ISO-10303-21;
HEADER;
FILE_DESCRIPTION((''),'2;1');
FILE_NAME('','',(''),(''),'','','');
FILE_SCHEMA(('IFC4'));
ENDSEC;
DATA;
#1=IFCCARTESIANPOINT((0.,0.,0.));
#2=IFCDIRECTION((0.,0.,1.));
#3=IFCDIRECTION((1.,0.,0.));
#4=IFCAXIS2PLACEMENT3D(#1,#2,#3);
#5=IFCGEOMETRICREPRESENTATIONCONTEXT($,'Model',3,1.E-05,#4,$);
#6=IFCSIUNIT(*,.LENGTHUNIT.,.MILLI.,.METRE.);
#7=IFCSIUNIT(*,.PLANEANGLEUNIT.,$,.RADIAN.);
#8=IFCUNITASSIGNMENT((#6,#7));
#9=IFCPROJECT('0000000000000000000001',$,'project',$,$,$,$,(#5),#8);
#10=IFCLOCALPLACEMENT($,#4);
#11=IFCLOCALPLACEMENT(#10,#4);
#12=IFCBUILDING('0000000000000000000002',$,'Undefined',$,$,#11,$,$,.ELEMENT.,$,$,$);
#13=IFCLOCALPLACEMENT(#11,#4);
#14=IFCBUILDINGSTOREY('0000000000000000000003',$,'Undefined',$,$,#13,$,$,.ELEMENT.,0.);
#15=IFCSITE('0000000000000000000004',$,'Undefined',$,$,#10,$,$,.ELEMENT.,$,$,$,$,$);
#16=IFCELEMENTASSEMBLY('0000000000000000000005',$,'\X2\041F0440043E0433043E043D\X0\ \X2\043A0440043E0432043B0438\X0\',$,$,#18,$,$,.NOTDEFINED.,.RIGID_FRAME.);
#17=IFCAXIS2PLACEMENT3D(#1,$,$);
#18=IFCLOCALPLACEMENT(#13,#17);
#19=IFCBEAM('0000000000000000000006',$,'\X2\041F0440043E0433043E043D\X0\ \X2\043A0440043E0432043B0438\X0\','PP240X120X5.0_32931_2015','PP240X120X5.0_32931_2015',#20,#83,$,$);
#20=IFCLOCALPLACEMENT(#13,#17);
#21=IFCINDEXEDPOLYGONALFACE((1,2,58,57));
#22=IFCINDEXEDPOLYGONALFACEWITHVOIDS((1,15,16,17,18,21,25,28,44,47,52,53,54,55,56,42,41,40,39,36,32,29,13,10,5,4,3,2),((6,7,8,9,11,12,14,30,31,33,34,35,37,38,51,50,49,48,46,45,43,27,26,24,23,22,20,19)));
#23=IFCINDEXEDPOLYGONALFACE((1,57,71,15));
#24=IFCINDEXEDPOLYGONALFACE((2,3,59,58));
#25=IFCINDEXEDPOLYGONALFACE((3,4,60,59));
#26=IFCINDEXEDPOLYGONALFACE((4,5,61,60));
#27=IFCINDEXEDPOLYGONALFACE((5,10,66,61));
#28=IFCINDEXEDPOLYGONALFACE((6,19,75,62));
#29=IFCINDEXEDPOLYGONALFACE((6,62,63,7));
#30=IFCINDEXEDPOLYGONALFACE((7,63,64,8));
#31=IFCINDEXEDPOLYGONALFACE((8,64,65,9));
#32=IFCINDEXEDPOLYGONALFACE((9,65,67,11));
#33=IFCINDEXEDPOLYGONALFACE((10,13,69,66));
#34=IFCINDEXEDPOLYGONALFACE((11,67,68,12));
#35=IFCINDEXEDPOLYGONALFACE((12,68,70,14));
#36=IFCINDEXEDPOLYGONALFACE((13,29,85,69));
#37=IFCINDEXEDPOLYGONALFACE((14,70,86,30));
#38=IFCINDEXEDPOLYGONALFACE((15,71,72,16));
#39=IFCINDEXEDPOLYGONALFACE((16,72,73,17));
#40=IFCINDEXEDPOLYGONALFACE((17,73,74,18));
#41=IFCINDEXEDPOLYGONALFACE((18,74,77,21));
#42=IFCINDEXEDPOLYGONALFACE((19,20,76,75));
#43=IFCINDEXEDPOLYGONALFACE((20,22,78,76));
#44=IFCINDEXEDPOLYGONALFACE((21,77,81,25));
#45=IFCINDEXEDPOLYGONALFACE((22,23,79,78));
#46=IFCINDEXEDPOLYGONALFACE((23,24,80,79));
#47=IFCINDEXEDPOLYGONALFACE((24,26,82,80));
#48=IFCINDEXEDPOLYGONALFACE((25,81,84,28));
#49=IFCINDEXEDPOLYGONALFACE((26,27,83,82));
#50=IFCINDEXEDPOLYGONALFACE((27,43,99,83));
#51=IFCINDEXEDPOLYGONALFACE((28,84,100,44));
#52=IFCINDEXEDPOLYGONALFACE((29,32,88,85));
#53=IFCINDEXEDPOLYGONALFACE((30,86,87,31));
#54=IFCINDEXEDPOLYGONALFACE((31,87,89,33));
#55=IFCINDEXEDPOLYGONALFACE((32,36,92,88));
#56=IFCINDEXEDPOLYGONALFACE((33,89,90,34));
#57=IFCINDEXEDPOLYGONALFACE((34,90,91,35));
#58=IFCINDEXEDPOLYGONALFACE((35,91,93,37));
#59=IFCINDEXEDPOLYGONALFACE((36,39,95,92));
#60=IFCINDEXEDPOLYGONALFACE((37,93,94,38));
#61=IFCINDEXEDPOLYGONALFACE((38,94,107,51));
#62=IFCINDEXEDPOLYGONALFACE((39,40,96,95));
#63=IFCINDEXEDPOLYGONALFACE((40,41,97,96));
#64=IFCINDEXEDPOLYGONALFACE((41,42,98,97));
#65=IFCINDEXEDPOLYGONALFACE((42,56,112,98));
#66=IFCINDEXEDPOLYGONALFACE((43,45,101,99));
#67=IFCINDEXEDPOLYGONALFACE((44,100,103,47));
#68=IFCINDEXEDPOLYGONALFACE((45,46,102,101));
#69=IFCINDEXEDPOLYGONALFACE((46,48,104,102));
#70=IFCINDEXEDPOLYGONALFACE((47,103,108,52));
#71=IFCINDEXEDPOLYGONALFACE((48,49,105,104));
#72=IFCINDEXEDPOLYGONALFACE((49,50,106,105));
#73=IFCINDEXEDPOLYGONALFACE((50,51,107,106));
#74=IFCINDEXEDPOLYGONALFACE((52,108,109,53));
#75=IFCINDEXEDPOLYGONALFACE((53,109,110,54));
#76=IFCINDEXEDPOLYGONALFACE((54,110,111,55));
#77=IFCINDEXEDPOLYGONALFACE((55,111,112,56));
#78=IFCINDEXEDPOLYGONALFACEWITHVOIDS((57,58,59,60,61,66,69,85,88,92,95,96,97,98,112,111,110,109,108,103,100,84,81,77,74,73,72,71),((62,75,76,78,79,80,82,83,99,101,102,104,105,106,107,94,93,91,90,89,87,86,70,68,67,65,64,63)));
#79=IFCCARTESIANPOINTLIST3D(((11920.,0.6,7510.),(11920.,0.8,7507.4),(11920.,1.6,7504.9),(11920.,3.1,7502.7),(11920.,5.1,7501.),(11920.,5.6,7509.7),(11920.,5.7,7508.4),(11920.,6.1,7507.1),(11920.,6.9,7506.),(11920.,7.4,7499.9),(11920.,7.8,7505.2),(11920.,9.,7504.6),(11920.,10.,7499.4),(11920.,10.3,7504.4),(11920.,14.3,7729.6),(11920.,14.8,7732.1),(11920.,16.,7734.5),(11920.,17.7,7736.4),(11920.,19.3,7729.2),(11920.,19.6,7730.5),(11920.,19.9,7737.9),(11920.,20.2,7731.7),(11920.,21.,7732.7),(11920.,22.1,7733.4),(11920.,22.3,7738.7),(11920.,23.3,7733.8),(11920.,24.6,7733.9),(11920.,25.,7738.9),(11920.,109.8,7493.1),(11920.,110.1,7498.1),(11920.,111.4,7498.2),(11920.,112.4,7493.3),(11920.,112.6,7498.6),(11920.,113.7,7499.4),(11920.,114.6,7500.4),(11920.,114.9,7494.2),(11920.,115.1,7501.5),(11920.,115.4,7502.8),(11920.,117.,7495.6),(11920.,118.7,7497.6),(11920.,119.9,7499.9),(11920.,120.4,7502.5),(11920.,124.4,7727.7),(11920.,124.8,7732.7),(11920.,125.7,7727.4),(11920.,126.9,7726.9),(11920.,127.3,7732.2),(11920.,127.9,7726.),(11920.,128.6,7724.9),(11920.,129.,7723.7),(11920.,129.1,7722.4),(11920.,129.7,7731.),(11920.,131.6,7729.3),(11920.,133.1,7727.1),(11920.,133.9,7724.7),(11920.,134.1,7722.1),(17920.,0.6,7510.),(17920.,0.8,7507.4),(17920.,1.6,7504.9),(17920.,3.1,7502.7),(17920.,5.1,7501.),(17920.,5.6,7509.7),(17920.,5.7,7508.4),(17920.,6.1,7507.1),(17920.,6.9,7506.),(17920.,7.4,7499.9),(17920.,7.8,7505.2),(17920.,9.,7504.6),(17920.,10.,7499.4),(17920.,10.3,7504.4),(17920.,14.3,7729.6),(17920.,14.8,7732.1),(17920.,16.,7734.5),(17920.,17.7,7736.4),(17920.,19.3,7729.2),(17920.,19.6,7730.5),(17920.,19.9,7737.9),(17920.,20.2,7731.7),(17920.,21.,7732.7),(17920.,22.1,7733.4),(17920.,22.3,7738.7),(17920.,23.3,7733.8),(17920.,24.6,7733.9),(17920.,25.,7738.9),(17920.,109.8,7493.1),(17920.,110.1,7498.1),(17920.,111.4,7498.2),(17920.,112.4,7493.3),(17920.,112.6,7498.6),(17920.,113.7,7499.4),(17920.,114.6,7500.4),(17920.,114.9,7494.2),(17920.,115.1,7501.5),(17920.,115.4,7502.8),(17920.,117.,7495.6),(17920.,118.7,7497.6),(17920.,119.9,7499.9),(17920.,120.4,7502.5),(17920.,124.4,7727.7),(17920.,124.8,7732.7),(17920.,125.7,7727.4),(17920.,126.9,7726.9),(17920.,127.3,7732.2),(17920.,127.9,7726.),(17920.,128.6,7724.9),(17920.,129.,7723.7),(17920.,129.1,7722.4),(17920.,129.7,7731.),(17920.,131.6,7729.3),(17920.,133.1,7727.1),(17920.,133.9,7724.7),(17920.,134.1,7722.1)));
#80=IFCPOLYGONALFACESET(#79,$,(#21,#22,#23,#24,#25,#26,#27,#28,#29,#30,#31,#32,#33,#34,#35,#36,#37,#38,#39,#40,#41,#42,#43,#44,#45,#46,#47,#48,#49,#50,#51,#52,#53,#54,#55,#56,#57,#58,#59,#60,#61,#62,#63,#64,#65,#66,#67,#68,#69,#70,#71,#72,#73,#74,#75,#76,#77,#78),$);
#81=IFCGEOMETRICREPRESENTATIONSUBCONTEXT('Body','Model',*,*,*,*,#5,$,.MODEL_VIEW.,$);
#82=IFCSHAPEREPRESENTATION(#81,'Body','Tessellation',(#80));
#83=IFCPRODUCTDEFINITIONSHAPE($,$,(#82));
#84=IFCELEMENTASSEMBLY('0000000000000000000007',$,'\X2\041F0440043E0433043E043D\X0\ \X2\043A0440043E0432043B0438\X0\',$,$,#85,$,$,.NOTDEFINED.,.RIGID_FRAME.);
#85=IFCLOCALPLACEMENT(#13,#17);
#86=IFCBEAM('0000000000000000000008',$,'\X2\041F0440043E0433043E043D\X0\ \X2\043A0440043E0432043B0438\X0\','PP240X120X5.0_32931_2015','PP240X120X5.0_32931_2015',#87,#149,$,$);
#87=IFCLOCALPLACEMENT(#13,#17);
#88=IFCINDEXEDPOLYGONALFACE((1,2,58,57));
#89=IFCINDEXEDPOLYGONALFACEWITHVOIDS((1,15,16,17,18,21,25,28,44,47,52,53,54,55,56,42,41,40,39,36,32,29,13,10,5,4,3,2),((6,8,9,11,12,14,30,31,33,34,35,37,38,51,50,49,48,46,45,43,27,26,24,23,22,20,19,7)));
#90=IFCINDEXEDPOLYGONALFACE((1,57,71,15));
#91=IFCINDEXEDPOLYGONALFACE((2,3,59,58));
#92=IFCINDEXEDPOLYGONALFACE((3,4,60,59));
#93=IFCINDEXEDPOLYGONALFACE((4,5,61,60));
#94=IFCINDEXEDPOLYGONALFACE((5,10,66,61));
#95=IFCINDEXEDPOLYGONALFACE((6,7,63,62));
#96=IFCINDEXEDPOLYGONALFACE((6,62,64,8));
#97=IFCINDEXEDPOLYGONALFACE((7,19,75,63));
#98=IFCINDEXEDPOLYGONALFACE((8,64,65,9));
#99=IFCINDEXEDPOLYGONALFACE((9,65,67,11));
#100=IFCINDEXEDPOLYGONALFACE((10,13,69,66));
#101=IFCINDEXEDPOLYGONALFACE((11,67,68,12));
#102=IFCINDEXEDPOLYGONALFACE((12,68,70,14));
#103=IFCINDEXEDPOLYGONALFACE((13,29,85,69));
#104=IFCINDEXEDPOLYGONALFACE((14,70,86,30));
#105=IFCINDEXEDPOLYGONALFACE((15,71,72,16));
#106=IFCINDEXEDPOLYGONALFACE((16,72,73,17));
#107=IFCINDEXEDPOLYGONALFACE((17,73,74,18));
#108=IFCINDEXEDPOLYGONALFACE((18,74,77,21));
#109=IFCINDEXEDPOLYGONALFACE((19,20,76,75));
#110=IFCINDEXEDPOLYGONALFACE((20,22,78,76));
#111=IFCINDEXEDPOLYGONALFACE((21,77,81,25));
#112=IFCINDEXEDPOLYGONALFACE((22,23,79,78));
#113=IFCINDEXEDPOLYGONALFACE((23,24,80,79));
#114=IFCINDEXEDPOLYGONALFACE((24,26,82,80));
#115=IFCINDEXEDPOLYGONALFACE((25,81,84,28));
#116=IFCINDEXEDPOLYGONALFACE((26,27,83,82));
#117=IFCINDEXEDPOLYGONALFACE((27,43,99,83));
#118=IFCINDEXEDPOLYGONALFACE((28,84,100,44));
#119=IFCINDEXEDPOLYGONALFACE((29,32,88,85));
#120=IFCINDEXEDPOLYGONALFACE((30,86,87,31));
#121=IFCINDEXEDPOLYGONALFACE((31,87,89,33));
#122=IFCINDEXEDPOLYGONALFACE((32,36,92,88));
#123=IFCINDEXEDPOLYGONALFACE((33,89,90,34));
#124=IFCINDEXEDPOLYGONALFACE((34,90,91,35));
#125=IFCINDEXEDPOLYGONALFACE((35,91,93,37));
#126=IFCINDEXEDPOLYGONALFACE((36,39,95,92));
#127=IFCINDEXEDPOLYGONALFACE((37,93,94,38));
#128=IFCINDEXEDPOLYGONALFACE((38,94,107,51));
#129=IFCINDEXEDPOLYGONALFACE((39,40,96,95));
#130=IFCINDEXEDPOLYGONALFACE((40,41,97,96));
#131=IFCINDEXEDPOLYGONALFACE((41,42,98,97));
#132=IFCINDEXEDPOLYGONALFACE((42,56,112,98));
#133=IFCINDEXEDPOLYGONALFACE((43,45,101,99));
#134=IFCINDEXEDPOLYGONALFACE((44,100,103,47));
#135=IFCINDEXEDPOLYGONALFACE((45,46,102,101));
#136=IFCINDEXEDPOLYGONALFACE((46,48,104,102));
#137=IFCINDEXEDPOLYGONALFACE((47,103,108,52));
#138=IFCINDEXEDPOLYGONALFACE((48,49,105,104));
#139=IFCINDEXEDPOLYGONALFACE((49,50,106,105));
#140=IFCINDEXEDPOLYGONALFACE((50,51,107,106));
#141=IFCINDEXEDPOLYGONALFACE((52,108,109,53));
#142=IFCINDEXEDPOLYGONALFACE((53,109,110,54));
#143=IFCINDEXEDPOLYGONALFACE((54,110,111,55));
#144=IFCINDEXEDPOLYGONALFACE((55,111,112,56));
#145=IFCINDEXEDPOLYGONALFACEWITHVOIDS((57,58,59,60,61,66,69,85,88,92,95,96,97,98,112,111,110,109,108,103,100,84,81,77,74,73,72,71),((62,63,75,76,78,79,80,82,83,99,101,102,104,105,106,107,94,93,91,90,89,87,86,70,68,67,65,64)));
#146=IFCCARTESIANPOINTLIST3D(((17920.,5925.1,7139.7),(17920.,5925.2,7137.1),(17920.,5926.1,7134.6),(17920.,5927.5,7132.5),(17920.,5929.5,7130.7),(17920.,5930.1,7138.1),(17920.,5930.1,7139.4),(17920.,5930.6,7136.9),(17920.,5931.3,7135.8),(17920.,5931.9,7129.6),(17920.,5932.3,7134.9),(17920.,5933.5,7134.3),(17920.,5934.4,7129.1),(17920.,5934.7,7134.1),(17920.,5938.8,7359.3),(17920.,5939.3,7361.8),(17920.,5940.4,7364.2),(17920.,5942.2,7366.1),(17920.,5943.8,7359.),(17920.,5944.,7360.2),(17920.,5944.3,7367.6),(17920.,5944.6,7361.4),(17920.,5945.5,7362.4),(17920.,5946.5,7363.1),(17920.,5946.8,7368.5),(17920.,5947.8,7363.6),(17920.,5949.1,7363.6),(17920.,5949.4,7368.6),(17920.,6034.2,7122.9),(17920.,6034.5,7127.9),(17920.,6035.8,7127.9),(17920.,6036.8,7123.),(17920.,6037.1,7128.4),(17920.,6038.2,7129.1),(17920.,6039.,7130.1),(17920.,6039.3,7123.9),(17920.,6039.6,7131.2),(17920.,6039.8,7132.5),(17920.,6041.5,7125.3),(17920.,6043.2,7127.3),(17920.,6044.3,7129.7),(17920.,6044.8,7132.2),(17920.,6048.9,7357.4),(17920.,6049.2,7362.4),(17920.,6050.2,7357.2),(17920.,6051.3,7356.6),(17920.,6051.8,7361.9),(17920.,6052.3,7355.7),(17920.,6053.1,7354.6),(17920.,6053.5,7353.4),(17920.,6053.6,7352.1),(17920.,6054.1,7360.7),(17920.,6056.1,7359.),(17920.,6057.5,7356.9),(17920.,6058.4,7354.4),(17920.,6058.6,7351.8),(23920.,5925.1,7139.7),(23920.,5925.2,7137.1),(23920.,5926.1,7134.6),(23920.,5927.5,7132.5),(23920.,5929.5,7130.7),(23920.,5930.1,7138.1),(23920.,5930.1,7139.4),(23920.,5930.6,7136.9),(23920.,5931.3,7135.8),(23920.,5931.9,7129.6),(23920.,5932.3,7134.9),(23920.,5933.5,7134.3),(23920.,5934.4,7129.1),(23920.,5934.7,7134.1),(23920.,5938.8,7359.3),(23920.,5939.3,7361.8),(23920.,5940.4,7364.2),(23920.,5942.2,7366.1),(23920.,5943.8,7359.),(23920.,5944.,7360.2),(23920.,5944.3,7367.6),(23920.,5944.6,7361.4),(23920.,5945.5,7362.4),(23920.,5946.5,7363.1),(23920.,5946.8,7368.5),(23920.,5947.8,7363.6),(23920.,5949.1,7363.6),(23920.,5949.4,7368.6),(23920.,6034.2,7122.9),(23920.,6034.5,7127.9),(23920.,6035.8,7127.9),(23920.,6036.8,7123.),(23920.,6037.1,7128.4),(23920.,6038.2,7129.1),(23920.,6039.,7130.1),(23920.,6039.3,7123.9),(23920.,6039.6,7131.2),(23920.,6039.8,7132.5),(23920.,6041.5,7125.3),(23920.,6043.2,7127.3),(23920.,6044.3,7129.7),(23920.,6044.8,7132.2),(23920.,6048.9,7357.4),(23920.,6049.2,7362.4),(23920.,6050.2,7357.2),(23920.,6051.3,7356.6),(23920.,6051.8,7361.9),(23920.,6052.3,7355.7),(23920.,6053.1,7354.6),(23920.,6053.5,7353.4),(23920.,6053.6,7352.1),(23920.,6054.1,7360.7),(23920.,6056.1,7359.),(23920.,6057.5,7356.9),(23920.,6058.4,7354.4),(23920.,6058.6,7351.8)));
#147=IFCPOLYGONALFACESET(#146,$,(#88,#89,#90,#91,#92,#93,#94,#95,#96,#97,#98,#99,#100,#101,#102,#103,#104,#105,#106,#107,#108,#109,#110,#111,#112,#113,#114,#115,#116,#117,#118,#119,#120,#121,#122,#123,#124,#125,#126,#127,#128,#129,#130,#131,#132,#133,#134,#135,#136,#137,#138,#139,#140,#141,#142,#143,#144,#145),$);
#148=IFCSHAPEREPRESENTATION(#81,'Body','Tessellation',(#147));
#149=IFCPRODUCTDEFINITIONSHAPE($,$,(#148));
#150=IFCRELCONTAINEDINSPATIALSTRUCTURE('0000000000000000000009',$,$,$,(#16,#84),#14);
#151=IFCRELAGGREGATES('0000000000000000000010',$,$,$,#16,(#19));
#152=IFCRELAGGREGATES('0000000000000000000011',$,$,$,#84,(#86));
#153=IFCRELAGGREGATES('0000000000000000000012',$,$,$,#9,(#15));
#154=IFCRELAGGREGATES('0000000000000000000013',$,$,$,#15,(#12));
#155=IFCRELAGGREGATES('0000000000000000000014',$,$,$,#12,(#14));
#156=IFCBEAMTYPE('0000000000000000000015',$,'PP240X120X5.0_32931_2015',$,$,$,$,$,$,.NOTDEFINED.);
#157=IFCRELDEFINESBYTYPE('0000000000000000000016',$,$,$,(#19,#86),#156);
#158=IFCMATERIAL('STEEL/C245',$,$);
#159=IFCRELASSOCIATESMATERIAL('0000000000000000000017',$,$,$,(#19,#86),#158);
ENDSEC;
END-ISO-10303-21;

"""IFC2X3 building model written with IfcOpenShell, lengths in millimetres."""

from ifc_helpers import new_model, si_unit, frame, origin_with_axes, origin_2d_with_axis, place, context, subcontext, project, spatial, hollow_rectangle, extrude, material, type_object, element, aggregate, save


model = new_model("IFC2X3")

# Units and contexts
model_context = context("Model", 3, precision=1e-05, world=origin_with_axes())
body_context = subcontext(model_context, "Body", "Model", "MODEL_VIEW")
ifc_project = project(units=[si_unit("LENGTHUNIT", "METRE", prefix="MILLI"), si_unit("PLANEANGLEUNIT", "RADIAN")], contexts=[model_context])

# Site, building, storey
site_placement = place(None, origin_with_axes())
site = spatial("IfcSite", under=ifc_project, at=site_placement, Name="Undefined", CompositionType="ELEMENT")
building_placement = place(site_placement, origin_with_axes())
building = spatial("IfcBuilding", under=site, at=building_placement, Name="Undefined", CompositionType="ELEMENT")
storey_placement = place(building_placement, origin_with_axes())
storey = spatial("IfcBuildingStorey", under=building, at=storey_placement, Name="Undefined", CompositionType="ELEMENT", Elevation=0.0)

# Shared definitions
ifc_material = material(Name="STEEL/C245")

# Element assemblies, beams
beam_type_1 = type_object("IfcBeamType", Name="PP240X120X5.0_32931_2015", PredefinedType="NOTDEFINED")
assembly_1_placement = place(storey_placement, origin_with_axes())
assembly_1 = element("IfcElementAssembly", 1, at=assembly_1_placement, inside=storey, Name="Прогон кровли", AssemblyPlace="NOTDEFINED", PredefinedType="RIGID_FRAME")
beam_1_placement = place(assembly_1_placement, frame((17920.0, 67.4, 7616.0), z_axis=(0.0, 0.062378, 0.998053), x_axis=(-1.0, 0.0, 0.0)))
beam_1 = element("IfcBeam", 2, at=beam_1_placement, type_object=beam_type_1, material=ifc_material, Name="Прогон кровли", Description="PP240X120X5.0_32931_2015", ObjectType="PP240X120X5.0_32931_2015", context=body_context, shape_type="SweptSolid", body=[
    extrude(hollow_rectangle(XDim=120.0, YDim=240.0, WallThickness=5.0, InnerFilletRadius=5.0, OuterFilletRadius=10.0, at=origin_2d_with_axis()), frame((6000.0, 0.0, 0.0), z_axis=(-1.0, 0.0, 0.0), x_axis=(0.0, -1.0, 0.0)), (0.0, 0.0, 1.0), 6000.0),
])
aggregate(assembly_1, [beam_1])
assembly_2_placement = place(storey_placement, origin_with_axes())
assembly_2 = element("IfcElementAssembly", 3, at=assembly_2_placement, inside=storey, Name="Прогон кровли", AssemblyPlace="NOTDEFINED", PredefinedType="RIGID_FRAME")
beam_2_placement = place(assembly_2_placement, frame((23920.0, 5991.8, 7245.7), z_axis=(0.0, 0.062378, 0.998053), x_axis=(-1.0, 0.0, 0.0)))
beam_2 = element("IfcBeam", 4, at=beam_2_placement, type_object=beam_type_1, material=ifc_material, Name="Прогон кровли", Description="PP240X120X5.0_32931_2015", ObjectType="PP240X120X5.0_32931_2015", context=body_context, shape_type="SweptSolid", body=[
    extrude(hollow_rectangle(XDim=120.0, YDim=240.0, WallThickness=5.0, InnerFilletRadius=5.0, OuterFilletRadius=10.0, at=origin_2d_with_axis()), frame((6000.0, 0.0, 0.0), z_axis=(-1.0, 0.0, 0.0), x_axis=(0.0, -1.0, 0.0)), (0.0, 0.0, 1.0), 6000.0),
])
aggregate(assembly_2, [beam_2])

save(model, "model.ifc")
